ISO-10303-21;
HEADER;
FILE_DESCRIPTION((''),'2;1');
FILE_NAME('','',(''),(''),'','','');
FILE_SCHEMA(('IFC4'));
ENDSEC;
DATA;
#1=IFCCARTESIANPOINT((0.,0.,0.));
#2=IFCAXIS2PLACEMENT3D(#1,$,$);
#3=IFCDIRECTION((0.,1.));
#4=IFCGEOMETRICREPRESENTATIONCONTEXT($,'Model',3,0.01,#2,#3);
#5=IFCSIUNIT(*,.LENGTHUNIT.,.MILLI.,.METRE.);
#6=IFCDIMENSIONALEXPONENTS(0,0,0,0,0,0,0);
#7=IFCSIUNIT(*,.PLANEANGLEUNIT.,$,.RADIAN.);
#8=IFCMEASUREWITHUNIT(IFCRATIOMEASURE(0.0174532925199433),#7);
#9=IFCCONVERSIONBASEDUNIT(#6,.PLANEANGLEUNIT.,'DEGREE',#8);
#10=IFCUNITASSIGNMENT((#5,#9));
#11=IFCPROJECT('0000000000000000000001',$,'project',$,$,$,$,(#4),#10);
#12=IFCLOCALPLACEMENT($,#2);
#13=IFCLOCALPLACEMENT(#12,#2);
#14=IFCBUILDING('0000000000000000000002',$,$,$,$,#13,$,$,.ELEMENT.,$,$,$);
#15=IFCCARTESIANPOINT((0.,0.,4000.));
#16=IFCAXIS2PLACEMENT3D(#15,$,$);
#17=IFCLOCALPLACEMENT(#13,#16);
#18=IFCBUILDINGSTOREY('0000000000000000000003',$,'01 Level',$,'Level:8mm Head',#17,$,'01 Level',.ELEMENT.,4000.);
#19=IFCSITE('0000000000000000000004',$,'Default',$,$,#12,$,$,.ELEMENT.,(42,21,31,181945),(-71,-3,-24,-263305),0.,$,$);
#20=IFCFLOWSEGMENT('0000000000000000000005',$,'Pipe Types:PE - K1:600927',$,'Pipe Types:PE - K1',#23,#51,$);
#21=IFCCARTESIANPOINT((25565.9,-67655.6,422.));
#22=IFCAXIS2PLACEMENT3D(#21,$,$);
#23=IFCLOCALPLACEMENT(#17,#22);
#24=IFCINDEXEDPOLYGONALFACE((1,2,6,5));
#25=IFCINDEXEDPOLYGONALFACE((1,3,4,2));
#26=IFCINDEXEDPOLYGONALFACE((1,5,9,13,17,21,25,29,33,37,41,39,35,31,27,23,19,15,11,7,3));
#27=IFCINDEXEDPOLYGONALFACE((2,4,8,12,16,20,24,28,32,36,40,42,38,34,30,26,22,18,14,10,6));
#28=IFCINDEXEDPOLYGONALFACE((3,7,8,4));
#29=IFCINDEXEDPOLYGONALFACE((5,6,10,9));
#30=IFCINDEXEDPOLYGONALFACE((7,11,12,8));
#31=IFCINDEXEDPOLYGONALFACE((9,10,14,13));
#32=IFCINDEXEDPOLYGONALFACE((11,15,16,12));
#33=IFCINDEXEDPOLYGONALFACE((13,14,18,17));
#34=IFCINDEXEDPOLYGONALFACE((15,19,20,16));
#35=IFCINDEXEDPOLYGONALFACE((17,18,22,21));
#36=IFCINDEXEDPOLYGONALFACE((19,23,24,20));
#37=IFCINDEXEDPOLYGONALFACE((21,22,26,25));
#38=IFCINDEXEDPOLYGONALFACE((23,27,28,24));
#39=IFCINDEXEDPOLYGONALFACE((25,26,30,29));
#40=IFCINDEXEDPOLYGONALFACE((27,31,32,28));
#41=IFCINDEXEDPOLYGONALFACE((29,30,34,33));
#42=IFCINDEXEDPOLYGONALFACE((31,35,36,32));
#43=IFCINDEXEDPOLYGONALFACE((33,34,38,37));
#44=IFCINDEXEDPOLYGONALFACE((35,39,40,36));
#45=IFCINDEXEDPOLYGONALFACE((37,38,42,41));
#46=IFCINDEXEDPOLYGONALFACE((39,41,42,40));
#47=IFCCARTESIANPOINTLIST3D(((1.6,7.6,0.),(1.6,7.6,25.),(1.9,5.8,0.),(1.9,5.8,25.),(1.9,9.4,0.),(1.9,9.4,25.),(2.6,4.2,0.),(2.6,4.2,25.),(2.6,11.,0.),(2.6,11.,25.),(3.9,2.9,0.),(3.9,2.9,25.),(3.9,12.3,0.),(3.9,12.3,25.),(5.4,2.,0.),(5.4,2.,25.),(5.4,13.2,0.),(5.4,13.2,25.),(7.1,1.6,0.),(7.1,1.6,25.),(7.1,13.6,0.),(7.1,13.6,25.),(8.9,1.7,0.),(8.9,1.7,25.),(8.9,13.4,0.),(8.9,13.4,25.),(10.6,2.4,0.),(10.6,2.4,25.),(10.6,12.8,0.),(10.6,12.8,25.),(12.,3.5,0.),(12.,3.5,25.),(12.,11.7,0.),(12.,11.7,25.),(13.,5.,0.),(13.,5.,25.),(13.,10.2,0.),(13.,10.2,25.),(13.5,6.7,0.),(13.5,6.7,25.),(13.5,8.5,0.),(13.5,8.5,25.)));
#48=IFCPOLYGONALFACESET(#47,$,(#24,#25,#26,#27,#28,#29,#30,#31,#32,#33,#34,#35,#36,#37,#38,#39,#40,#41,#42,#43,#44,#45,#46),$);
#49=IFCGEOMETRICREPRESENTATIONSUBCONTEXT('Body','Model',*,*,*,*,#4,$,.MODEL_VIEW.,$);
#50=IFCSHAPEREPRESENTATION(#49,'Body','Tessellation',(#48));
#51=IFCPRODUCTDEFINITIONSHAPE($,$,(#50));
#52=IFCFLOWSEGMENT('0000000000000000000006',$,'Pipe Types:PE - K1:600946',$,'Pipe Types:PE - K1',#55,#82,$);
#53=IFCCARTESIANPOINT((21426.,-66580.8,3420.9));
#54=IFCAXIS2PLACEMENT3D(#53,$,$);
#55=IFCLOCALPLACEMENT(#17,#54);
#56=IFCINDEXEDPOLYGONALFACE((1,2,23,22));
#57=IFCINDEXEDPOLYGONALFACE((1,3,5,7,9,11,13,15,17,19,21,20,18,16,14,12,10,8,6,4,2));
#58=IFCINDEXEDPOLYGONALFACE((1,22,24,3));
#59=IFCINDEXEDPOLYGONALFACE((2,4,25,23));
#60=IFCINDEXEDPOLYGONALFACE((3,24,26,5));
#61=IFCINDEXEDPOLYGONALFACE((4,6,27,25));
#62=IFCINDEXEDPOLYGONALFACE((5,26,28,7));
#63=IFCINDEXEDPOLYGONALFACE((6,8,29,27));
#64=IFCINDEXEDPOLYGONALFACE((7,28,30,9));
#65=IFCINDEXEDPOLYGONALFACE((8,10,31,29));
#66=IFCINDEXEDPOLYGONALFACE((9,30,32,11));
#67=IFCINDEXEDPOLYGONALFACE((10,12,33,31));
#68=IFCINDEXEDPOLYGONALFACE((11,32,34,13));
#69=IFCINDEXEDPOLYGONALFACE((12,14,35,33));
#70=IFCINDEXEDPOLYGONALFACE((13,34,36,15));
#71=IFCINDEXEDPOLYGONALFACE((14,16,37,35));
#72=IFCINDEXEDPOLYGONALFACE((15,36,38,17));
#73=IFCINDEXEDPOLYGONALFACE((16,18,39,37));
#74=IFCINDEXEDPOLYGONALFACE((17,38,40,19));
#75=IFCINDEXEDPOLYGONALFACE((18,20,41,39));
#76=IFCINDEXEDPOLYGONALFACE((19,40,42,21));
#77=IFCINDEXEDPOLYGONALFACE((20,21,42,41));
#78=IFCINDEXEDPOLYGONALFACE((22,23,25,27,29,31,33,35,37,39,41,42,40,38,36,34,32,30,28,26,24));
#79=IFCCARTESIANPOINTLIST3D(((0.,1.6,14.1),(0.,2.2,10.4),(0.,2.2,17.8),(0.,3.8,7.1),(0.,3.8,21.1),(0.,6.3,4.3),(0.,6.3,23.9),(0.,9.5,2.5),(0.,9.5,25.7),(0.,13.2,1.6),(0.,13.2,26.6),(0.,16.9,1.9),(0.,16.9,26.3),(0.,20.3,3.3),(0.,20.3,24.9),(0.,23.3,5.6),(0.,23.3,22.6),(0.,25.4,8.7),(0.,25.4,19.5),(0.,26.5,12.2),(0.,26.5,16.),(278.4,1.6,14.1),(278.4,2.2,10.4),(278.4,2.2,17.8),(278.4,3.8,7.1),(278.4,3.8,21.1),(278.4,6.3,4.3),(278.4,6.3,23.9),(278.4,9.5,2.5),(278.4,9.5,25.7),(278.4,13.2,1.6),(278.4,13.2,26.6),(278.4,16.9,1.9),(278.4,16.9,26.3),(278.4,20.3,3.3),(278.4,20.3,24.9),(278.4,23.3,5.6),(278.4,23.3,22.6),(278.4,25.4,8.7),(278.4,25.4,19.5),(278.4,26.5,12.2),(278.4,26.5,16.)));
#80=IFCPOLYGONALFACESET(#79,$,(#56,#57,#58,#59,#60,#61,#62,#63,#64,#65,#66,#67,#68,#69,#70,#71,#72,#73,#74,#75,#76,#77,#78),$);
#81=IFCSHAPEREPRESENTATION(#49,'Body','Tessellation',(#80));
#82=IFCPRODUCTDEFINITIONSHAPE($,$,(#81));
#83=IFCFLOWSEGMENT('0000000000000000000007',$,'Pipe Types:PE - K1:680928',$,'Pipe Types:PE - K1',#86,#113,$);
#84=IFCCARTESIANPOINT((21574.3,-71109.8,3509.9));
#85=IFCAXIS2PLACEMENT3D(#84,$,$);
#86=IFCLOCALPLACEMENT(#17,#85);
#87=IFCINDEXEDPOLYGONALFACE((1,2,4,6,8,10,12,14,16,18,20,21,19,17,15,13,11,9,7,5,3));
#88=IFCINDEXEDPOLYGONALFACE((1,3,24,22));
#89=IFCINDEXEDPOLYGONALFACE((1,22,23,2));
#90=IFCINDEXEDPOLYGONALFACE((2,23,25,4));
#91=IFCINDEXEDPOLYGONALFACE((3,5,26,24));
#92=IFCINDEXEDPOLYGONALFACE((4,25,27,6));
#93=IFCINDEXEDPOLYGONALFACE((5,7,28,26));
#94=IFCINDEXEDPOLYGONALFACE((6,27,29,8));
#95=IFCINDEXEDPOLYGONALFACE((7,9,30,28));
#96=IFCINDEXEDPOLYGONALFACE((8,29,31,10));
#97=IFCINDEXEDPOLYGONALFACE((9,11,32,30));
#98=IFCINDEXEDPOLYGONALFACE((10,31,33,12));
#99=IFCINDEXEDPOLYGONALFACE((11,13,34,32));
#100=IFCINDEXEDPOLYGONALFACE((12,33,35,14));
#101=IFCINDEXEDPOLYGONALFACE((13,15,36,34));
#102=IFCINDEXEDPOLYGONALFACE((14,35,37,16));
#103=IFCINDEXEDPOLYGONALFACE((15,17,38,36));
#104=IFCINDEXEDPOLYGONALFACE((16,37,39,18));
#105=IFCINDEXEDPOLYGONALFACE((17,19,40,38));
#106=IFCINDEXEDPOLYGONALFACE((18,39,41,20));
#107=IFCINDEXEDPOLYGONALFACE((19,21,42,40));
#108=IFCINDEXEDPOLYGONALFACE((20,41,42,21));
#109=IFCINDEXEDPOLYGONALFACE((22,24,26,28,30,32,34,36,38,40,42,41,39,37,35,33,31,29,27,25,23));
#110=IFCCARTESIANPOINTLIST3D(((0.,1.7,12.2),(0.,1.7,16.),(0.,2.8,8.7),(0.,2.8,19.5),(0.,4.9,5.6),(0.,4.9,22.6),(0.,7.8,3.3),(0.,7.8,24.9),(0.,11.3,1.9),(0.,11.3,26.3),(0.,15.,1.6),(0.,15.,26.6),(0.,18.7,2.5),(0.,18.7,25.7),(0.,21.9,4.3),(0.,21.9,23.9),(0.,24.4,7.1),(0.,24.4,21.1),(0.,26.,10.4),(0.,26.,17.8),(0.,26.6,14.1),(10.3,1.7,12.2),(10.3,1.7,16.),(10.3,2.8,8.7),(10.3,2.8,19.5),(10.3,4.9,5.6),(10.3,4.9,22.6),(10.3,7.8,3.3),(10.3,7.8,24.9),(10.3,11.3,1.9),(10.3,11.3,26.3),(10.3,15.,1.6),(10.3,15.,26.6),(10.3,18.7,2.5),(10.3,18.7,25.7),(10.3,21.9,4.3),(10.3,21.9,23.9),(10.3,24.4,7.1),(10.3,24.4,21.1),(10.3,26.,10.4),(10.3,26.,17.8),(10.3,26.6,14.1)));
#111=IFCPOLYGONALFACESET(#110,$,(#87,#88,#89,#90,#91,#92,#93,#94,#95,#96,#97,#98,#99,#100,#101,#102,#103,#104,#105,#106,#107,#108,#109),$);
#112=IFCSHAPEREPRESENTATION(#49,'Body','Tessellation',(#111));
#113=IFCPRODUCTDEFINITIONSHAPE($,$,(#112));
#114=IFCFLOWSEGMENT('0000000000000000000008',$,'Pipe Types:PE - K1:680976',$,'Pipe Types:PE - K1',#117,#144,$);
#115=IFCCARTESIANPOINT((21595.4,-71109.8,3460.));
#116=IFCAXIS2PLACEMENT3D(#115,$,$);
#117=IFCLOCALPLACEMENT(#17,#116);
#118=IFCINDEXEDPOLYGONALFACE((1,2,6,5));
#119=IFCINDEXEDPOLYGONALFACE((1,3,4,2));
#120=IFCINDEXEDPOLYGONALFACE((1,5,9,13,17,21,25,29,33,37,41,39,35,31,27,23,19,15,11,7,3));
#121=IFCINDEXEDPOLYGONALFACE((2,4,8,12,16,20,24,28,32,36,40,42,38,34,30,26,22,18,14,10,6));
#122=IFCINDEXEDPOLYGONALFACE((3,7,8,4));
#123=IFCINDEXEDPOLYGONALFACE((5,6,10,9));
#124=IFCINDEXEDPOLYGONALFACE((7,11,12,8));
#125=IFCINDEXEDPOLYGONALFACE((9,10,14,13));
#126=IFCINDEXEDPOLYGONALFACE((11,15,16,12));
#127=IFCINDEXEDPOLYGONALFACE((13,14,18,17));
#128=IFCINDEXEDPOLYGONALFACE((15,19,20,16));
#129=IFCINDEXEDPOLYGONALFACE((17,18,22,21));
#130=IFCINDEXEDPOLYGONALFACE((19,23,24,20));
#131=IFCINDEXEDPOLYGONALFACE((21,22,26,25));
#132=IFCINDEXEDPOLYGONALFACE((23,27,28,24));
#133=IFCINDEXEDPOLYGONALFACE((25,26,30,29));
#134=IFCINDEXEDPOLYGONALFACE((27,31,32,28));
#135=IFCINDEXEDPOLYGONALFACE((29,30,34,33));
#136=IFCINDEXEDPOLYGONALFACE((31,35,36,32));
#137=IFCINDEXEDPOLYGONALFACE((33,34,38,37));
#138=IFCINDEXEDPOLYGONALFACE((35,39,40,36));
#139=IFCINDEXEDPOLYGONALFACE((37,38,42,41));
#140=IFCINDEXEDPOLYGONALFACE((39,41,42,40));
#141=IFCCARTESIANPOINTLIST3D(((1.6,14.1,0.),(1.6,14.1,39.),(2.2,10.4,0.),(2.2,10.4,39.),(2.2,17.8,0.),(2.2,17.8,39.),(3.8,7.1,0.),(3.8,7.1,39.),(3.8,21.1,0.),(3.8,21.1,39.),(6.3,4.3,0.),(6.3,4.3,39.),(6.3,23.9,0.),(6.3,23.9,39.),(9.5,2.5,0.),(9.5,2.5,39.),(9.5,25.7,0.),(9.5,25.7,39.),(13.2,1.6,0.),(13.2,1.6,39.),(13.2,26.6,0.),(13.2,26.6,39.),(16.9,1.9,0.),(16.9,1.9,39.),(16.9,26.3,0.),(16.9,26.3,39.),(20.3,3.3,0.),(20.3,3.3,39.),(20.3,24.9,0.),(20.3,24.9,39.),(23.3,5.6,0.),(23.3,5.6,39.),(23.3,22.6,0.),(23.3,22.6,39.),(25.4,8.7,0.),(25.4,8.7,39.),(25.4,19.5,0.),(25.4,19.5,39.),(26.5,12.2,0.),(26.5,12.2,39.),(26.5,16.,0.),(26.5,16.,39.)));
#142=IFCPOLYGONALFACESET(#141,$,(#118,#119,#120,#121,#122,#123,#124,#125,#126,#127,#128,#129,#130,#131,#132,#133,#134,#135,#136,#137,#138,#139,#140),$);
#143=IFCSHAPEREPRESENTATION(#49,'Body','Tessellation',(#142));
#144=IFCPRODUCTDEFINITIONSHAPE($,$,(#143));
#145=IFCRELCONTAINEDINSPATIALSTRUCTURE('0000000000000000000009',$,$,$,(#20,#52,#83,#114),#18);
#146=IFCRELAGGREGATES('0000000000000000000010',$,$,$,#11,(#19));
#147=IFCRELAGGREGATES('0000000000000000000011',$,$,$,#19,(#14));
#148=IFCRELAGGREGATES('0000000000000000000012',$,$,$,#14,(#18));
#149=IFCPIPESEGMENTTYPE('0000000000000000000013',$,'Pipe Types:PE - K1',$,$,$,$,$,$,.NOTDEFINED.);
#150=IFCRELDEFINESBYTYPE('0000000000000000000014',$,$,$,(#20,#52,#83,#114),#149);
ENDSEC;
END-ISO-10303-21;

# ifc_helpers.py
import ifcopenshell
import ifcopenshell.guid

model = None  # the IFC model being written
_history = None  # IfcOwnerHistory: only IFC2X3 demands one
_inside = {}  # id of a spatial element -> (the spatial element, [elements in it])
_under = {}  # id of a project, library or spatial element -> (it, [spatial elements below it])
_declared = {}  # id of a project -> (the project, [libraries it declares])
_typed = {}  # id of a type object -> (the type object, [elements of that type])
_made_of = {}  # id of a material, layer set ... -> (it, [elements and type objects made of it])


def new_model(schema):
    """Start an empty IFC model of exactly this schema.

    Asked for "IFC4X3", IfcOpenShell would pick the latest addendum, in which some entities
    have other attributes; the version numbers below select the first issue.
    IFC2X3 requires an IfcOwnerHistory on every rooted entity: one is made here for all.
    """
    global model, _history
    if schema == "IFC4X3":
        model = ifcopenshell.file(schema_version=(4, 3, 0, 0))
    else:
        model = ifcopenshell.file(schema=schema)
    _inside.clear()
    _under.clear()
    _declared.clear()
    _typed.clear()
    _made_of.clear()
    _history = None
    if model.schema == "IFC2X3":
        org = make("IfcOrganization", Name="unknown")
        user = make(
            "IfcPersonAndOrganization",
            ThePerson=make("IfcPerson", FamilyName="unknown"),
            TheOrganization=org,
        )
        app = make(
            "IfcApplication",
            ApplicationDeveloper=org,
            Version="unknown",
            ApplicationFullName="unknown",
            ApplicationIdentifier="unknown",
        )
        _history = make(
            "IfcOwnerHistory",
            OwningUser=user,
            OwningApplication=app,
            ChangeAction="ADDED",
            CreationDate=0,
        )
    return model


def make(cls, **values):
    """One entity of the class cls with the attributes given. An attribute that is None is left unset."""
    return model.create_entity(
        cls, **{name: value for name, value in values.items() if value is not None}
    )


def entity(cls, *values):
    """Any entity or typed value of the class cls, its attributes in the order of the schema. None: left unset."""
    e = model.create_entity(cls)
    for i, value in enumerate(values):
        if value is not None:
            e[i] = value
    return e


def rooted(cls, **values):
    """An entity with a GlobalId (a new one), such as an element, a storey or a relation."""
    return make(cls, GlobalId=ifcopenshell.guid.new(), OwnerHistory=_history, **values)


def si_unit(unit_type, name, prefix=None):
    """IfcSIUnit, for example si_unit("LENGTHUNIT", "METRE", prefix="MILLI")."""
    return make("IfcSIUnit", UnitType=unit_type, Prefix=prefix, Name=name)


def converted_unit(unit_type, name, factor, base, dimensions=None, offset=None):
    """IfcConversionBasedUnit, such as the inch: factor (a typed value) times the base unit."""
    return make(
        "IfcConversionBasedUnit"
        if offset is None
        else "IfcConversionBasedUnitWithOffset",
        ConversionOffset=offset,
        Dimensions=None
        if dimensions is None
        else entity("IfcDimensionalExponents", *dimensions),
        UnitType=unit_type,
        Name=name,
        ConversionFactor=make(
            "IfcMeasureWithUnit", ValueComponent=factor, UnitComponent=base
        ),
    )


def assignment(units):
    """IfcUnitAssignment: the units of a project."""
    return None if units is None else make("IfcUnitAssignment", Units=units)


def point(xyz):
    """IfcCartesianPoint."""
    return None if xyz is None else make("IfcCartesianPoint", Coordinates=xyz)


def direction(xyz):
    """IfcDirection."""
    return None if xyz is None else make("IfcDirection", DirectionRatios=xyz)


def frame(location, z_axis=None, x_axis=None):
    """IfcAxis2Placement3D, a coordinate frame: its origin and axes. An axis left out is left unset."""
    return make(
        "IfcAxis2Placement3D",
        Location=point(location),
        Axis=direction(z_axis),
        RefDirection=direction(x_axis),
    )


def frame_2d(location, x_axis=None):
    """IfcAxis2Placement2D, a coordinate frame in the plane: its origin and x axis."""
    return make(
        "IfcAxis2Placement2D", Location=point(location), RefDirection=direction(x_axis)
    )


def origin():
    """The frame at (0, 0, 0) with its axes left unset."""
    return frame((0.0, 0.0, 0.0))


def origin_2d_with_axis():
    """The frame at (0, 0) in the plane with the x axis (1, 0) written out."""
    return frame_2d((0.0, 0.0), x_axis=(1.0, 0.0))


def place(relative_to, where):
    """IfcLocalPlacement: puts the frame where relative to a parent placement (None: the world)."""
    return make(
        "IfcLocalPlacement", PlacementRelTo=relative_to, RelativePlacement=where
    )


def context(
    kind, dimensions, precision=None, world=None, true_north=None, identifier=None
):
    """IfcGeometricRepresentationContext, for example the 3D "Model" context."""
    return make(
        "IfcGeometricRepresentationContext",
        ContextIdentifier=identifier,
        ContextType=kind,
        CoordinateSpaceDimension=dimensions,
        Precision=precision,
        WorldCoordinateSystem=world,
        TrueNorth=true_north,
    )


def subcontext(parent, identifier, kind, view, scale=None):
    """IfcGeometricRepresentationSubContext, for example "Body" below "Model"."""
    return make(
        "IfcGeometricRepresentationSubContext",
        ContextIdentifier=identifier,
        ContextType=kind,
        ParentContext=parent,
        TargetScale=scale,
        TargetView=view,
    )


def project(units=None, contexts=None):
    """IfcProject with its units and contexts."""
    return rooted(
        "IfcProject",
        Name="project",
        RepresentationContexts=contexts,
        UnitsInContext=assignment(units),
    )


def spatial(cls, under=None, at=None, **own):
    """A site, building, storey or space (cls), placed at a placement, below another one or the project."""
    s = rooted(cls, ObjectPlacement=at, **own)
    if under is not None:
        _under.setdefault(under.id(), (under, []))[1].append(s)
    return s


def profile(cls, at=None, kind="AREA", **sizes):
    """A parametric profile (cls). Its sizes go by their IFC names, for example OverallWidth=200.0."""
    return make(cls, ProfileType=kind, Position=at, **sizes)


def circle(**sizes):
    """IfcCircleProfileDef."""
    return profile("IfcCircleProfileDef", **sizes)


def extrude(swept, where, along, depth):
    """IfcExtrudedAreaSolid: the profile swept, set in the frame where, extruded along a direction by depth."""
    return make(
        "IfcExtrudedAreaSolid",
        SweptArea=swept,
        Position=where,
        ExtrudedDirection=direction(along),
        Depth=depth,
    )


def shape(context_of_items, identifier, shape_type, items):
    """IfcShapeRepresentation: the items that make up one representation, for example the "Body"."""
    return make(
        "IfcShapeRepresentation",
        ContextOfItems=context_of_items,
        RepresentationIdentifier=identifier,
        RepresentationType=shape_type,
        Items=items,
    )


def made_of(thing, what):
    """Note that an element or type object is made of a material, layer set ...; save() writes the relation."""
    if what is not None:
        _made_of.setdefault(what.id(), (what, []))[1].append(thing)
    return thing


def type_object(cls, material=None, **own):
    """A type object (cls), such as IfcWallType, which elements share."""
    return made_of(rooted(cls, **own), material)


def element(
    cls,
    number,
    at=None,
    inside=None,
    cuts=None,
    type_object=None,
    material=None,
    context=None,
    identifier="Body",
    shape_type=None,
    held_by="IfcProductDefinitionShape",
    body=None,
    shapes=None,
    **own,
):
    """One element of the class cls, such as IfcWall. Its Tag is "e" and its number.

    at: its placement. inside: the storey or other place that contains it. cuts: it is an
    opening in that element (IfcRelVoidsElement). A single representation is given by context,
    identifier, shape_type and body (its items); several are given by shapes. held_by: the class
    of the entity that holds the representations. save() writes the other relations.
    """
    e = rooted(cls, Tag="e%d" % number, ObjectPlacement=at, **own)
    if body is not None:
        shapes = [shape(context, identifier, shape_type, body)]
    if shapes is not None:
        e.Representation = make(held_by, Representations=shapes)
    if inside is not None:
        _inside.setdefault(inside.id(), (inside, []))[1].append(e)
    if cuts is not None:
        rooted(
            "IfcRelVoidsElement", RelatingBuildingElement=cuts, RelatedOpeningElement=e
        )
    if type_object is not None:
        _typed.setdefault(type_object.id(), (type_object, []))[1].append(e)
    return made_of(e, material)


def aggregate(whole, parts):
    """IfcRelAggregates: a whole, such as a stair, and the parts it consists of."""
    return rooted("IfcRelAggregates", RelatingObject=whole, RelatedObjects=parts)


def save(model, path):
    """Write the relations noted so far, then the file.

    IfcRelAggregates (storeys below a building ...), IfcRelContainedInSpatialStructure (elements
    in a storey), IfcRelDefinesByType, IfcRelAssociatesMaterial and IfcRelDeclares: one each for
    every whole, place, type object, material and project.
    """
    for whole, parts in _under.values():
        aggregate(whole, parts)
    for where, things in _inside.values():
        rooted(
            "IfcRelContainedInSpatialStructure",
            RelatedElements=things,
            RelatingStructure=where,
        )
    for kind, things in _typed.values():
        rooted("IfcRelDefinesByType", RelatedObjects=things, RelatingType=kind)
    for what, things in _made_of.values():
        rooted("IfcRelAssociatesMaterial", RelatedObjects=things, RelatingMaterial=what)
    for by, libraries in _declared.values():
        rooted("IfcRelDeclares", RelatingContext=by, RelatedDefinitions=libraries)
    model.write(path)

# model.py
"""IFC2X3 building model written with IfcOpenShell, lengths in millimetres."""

from ifc_helpers import new_model, entity, si_unit, converted_unit, direction, frame, origin, origin_2d_with_axis, place, context, subcontext, project, spatial, circle, extrude, type_object, element, save


model = new_model("IFC2X3")

# Units and contexts
model_context = context("Model", 3, precision=0.01, world=origin(), true_north=direction((0.0, 1.0)))
body_context = subcontext(model_context, "Body", "Model", "MODEL_VIEW")
ifc_project = project(units=[si_unit("LENGTHUNIT", "METRE", prefix="MILLI"), converted_unit("PLANEANGLEUNIT", "DEGREE", entity("IfcRatioMeasure", 0.0174532925199433), si_unit("PLANEANGLEUNIT", "RADIAN"), dimensions=[0, 0, 0, 0, 0, 0, 0])], contexts=[model_context])

# Site, building, storey
site_placement = place(None, origin())
site = spatial("IfcSite", under=ifc_project, at=site_placement, Name="Default", CompositionType="ELEMENT", RefLatitude=(42, 21, 31, 181945), RefLongitude=(-71, -3, -24, -263305), RefElevation=0.0)
building_placement = place(site_placement, origin())
building = spatial("IfcBuilding", under=site, at=building_placement, CompositionType="ELEMENT")
storey_placement = place(building_placement, frame((0.0, 0.0, 4000.0)))
storey = spatial("IfcBuildingStorey", under=building, at=storey_placement, Name="01 Level", ObjectType="Level:8mm Head", LongName="01 Level", CompositionType="ELEMENT", Elevation=4000.0)

# Flow segments
pipe_segment_type = type_object("IfcPipeSegmentType", Name="Pipe Types:PE - K1", PredefinedType="NOTDEFINED")
flow_segment_1_placement = place(storey_placement, frame((25565.9, -67655.6, 422.0)))
element("IfcFlowSegment", 1, at=flow_segment_1_placement, inside=storey, type_object=pipe_segment_type, Name="Pipe Types:PE - K1:600927", ObjectType="Pipe Types:PE - K1", context=body_context, shape_type="SweptSolid", body=[
    extrude(circle(Radius=6.0, at=origin_2d_with_axis()), frame((7.6, 7.6, 0.0), z_axis=(0.0, 0.0, 1.0), x_axis=(-1.0, 0.0, 0.0)), (0.0, 0.0, 1.0), 25.0),
])
flow_segment_2_placement = place(storey_placement, frame((21426.0, -66580.8, 3420.9)))
element("IfcFlowSegment", 2, at=flow_segment_2_placement, inside=storey, type_object=pipe_segment_type, Name="Pipe Types:PE - K1:600946", ObjectType="Pipe Types:PE - K1", context=body_context, shape_type="SweptSolid", body=[
    extrude(circle(Radius=12.5, at=origin_2d_with_axis()), frame((0.0, 14.1, 14.1), z_axis=(1.0, 0.0, 0.0), x_axis=(0.0, -1.0, 0.0)), (0.0, 0.0, 1.0), 278.4),
])
flow_segment_3_placement = place(storey_placement, frame((21574.3, -71109.8, 3509.9)))
element("IfcFlowSegment", 3, at=flow_segment_3_placement, inside=storey, type_object=pipe_segment_type, Name="Pipe Types:PE - K1:680928", ObjectType="Pipe Types:PE - K1", context=body_context, shape_type="SweptSolid", body=[
    extrude(circle(Radius=12.5, at=origin_2d_with_axis()), frame((0.0, 14.1, 14.1), z_axis=(1.0, 0.0, 0.0), x_axis=(0.0, 1.0, 0.0)), (0.0, 0.0, 1.0), 10.3),
])
flow_segment_4_placement = place(storey_placement, frame((21595.4, -71109.8, 3460.0)))
element("IfcFlowSegment", 4, at=flow_segment_4_placement, inside=storey, type_object=pipe_segment_type, Name="Pipe Types:PE - K1:680976", ObjectType="Pipe Types:PE - K1", context=body_context, shape_type="SweptSolid", body=[
    extrude(circle(Radius=12.5, at=origin_2d_with_axis()), frame((14.1, 14.1, 0.0), z_axis=(0.0, 0.0, 1.0), x_axis=(-1.0, 0.0, 0.0)), (0.0, 0.0, 1.0), 39.0),
])

save(model, "model.ifc")
